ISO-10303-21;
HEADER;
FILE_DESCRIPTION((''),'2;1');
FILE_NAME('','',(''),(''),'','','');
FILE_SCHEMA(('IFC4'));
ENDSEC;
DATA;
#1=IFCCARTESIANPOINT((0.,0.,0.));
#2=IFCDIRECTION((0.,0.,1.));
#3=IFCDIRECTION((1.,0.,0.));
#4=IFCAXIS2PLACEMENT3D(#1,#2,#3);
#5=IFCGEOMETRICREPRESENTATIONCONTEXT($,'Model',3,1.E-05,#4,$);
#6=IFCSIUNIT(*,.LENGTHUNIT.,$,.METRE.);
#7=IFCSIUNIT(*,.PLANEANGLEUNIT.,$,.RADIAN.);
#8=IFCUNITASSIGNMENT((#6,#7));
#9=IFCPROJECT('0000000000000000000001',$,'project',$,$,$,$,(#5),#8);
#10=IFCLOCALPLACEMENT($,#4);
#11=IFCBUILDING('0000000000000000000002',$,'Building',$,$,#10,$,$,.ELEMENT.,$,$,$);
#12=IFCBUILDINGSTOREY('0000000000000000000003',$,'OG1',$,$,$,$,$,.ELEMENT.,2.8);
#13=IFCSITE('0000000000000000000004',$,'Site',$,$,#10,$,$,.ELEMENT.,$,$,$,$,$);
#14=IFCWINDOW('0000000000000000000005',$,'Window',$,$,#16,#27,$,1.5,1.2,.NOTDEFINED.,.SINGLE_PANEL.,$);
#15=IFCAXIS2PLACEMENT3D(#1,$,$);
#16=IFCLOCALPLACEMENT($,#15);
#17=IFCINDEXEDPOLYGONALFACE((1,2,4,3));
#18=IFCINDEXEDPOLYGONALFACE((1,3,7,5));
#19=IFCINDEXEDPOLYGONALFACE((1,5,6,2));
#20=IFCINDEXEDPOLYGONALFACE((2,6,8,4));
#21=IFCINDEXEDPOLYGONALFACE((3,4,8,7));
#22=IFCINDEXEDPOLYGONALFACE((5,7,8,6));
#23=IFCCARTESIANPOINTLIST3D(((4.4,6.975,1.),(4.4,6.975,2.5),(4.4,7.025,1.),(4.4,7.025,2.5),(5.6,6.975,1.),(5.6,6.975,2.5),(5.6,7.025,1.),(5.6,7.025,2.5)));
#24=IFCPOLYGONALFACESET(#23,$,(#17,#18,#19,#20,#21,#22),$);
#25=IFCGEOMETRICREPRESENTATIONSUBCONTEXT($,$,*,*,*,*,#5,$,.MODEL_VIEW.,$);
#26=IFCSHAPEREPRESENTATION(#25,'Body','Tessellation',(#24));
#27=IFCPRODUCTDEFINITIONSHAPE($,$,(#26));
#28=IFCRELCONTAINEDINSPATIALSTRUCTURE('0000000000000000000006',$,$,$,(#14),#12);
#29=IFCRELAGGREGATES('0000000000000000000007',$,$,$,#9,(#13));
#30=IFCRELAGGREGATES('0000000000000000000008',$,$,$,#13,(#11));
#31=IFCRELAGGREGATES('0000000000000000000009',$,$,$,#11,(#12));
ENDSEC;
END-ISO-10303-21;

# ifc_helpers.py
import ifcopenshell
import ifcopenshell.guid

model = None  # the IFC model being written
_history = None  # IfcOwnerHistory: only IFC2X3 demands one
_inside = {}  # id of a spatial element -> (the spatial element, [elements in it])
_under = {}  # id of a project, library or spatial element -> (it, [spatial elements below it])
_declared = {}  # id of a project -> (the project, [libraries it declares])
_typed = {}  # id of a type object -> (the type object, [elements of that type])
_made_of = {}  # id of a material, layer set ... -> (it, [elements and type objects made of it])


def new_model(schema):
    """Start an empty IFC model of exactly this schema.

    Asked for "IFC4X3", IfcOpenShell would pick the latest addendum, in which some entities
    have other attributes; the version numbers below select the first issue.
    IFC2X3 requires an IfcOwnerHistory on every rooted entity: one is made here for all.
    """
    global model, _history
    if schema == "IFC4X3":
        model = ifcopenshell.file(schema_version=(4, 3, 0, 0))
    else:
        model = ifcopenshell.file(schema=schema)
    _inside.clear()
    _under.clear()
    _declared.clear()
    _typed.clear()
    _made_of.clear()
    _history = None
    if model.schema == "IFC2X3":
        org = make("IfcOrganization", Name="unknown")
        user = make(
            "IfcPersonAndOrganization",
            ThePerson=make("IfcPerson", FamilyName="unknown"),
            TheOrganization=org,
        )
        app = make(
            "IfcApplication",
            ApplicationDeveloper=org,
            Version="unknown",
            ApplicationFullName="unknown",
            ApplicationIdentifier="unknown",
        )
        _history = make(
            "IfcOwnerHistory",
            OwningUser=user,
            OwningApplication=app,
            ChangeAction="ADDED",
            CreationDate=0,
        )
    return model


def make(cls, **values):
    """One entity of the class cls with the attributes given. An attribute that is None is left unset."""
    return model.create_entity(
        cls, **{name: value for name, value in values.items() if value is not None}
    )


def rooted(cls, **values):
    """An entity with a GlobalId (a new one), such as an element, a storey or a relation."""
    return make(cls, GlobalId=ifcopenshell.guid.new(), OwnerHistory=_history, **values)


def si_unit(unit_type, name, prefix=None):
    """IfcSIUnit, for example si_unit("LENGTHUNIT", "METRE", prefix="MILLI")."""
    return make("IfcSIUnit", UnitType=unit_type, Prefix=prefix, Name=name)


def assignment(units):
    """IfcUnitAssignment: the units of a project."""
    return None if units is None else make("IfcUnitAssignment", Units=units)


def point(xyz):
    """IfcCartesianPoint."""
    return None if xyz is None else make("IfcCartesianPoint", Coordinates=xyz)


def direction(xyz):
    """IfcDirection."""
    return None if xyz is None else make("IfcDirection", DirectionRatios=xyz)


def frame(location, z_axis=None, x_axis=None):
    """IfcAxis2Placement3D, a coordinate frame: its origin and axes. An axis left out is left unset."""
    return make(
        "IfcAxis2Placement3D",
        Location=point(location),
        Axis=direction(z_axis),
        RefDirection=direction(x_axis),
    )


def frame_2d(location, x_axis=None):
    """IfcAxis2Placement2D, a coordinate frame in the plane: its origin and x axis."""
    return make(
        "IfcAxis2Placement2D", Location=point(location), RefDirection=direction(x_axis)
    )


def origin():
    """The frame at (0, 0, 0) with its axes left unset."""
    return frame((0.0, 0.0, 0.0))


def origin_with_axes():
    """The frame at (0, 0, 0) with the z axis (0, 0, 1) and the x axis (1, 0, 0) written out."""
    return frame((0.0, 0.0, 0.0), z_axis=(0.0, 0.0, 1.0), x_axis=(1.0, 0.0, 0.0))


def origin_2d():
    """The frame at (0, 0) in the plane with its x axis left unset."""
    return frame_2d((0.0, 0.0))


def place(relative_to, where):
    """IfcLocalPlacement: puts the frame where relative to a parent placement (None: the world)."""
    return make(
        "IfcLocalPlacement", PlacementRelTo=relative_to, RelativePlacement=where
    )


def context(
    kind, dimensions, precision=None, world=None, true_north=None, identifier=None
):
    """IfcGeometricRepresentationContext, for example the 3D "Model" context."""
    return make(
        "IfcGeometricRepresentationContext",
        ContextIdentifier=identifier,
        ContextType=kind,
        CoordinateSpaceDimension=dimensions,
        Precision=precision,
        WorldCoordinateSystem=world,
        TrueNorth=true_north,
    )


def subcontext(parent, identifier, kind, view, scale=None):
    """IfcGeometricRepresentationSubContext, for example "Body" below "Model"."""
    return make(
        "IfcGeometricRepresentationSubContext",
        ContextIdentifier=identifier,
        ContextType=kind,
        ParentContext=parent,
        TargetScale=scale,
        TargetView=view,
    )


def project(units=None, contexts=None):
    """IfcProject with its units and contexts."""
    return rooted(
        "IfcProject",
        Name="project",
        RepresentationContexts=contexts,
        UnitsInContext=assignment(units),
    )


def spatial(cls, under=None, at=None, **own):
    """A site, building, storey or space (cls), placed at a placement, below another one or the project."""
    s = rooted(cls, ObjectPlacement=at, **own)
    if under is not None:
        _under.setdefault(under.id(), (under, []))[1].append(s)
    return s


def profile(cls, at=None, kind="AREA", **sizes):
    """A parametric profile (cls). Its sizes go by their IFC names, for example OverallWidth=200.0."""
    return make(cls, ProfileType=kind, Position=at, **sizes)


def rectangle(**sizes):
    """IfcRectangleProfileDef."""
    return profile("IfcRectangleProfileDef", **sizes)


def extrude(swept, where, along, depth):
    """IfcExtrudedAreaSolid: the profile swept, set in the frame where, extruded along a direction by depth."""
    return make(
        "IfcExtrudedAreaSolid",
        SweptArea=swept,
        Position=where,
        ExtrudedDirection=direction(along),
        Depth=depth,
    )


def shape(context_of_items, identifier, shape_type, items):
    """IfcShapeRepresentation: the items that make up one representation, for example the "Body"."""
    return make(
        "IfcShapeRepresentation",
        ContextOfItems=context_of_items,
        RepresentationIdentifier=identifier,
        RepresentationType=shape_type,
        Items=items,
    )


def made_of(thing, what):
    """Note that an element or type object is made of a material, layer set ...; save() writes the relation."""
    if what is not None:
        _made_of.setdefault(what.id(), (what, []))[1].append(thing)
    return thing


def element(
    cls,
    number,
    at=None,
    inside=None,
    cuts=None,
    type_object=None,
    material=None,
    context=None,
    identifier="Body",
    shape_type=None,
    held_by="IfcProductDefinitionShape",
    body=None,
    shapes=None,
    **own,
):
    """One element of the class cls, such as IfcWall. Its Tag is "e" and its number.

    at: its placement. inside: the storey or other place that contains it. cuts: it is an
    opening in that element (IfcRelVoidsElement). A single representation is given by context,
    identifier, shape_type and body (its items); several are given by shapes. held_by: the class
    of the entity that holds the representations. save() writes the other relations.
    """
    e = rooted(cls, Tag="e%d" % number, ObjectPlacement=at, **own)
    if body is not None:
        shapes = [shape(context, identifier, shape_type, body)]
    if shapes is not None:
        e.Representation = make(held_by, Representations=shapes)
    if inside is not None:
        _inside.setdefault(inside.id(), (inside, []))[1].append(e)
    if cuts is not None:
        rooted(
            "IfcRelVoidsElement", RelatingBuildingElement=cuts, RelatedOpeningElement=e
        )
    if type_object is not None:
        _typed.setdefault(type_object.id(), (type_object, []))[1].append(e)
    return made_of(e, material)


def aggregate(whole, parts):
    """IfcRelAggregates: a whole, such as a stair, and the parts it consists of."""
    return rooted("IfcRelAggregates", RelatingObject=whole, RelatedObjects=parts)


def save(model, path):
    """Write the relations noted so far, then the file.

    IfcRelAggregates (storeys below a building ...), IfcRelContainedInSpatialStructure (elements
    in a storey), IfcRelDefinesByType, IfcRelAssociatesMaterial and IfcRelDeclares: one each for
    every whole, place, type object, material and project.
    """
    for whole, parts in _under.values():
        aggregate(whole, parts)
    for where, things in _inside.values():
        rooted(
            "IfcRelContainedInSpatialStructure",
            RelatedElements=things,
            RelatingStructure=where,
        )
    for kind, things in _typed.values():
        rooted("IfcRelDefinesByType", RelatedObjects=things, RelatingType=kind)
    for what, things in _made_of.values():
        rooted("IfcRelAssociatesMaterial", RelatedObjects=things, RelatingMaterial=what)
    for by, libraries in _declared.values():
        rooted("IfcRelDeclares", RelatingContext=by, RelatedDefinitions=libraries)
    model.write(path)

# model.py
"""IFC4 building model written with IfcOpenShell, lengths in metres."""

from ifc_helpers import new_model, si_unit, frame, origin, origin_with_axes, origin_2d, place, context, subcontext, project, spatial, rectangle, extrude, element, save


model = new_model("IFC4")

# Units and contexts
model_context = context("Model", 3, precision=1e-05, world=origin_with_axes())
sub_context = subcontext(model_context, None, None, "MODEL_VIEW")
ifc_project = project(units=[si_unit("LENGTHUNIT", "METRE"), si_unit("PLANEANGLEUNIT", "RADIAN")], contexts=[model_context])

# Site, building, storey
placement_1 = place(None, origin_with_axes())
site = spatial("IfcSite", under=ifc_project, at=placement_1, Name="Site", CompositionType="ELEMENT")
building = spatial("IfcBuilding", under=site, at=placement_1, Name="Building", CompositionType="ELEMENT")
storey = spatial("IfcBuildingStorey", under=building, Name="OG1", CompositionType="ELEMENT", Elevation=2.8)

# Window
placement_2 = place(None, origin_with_axes())
window_placement = place(placement_2, frame((5.0, 7.0, 1.0)))
element("IfcWindow", 1, at=window_placement, inside=storey, Name="Window", OverallHeight=1.5, OverallWidth=1.2, PartitioningType="SINGLE_PANEL", PredefinedType="NOTDEFINED", context=sub_context, shape_type="SweptSolid", body=[
    extrude(rectangle(XDim=1.2, YDim=0.05, at=origin_2d()), origin(), (0.0, 0.0, 1.0), 1.5),
])

save(model, "model.ifc")
